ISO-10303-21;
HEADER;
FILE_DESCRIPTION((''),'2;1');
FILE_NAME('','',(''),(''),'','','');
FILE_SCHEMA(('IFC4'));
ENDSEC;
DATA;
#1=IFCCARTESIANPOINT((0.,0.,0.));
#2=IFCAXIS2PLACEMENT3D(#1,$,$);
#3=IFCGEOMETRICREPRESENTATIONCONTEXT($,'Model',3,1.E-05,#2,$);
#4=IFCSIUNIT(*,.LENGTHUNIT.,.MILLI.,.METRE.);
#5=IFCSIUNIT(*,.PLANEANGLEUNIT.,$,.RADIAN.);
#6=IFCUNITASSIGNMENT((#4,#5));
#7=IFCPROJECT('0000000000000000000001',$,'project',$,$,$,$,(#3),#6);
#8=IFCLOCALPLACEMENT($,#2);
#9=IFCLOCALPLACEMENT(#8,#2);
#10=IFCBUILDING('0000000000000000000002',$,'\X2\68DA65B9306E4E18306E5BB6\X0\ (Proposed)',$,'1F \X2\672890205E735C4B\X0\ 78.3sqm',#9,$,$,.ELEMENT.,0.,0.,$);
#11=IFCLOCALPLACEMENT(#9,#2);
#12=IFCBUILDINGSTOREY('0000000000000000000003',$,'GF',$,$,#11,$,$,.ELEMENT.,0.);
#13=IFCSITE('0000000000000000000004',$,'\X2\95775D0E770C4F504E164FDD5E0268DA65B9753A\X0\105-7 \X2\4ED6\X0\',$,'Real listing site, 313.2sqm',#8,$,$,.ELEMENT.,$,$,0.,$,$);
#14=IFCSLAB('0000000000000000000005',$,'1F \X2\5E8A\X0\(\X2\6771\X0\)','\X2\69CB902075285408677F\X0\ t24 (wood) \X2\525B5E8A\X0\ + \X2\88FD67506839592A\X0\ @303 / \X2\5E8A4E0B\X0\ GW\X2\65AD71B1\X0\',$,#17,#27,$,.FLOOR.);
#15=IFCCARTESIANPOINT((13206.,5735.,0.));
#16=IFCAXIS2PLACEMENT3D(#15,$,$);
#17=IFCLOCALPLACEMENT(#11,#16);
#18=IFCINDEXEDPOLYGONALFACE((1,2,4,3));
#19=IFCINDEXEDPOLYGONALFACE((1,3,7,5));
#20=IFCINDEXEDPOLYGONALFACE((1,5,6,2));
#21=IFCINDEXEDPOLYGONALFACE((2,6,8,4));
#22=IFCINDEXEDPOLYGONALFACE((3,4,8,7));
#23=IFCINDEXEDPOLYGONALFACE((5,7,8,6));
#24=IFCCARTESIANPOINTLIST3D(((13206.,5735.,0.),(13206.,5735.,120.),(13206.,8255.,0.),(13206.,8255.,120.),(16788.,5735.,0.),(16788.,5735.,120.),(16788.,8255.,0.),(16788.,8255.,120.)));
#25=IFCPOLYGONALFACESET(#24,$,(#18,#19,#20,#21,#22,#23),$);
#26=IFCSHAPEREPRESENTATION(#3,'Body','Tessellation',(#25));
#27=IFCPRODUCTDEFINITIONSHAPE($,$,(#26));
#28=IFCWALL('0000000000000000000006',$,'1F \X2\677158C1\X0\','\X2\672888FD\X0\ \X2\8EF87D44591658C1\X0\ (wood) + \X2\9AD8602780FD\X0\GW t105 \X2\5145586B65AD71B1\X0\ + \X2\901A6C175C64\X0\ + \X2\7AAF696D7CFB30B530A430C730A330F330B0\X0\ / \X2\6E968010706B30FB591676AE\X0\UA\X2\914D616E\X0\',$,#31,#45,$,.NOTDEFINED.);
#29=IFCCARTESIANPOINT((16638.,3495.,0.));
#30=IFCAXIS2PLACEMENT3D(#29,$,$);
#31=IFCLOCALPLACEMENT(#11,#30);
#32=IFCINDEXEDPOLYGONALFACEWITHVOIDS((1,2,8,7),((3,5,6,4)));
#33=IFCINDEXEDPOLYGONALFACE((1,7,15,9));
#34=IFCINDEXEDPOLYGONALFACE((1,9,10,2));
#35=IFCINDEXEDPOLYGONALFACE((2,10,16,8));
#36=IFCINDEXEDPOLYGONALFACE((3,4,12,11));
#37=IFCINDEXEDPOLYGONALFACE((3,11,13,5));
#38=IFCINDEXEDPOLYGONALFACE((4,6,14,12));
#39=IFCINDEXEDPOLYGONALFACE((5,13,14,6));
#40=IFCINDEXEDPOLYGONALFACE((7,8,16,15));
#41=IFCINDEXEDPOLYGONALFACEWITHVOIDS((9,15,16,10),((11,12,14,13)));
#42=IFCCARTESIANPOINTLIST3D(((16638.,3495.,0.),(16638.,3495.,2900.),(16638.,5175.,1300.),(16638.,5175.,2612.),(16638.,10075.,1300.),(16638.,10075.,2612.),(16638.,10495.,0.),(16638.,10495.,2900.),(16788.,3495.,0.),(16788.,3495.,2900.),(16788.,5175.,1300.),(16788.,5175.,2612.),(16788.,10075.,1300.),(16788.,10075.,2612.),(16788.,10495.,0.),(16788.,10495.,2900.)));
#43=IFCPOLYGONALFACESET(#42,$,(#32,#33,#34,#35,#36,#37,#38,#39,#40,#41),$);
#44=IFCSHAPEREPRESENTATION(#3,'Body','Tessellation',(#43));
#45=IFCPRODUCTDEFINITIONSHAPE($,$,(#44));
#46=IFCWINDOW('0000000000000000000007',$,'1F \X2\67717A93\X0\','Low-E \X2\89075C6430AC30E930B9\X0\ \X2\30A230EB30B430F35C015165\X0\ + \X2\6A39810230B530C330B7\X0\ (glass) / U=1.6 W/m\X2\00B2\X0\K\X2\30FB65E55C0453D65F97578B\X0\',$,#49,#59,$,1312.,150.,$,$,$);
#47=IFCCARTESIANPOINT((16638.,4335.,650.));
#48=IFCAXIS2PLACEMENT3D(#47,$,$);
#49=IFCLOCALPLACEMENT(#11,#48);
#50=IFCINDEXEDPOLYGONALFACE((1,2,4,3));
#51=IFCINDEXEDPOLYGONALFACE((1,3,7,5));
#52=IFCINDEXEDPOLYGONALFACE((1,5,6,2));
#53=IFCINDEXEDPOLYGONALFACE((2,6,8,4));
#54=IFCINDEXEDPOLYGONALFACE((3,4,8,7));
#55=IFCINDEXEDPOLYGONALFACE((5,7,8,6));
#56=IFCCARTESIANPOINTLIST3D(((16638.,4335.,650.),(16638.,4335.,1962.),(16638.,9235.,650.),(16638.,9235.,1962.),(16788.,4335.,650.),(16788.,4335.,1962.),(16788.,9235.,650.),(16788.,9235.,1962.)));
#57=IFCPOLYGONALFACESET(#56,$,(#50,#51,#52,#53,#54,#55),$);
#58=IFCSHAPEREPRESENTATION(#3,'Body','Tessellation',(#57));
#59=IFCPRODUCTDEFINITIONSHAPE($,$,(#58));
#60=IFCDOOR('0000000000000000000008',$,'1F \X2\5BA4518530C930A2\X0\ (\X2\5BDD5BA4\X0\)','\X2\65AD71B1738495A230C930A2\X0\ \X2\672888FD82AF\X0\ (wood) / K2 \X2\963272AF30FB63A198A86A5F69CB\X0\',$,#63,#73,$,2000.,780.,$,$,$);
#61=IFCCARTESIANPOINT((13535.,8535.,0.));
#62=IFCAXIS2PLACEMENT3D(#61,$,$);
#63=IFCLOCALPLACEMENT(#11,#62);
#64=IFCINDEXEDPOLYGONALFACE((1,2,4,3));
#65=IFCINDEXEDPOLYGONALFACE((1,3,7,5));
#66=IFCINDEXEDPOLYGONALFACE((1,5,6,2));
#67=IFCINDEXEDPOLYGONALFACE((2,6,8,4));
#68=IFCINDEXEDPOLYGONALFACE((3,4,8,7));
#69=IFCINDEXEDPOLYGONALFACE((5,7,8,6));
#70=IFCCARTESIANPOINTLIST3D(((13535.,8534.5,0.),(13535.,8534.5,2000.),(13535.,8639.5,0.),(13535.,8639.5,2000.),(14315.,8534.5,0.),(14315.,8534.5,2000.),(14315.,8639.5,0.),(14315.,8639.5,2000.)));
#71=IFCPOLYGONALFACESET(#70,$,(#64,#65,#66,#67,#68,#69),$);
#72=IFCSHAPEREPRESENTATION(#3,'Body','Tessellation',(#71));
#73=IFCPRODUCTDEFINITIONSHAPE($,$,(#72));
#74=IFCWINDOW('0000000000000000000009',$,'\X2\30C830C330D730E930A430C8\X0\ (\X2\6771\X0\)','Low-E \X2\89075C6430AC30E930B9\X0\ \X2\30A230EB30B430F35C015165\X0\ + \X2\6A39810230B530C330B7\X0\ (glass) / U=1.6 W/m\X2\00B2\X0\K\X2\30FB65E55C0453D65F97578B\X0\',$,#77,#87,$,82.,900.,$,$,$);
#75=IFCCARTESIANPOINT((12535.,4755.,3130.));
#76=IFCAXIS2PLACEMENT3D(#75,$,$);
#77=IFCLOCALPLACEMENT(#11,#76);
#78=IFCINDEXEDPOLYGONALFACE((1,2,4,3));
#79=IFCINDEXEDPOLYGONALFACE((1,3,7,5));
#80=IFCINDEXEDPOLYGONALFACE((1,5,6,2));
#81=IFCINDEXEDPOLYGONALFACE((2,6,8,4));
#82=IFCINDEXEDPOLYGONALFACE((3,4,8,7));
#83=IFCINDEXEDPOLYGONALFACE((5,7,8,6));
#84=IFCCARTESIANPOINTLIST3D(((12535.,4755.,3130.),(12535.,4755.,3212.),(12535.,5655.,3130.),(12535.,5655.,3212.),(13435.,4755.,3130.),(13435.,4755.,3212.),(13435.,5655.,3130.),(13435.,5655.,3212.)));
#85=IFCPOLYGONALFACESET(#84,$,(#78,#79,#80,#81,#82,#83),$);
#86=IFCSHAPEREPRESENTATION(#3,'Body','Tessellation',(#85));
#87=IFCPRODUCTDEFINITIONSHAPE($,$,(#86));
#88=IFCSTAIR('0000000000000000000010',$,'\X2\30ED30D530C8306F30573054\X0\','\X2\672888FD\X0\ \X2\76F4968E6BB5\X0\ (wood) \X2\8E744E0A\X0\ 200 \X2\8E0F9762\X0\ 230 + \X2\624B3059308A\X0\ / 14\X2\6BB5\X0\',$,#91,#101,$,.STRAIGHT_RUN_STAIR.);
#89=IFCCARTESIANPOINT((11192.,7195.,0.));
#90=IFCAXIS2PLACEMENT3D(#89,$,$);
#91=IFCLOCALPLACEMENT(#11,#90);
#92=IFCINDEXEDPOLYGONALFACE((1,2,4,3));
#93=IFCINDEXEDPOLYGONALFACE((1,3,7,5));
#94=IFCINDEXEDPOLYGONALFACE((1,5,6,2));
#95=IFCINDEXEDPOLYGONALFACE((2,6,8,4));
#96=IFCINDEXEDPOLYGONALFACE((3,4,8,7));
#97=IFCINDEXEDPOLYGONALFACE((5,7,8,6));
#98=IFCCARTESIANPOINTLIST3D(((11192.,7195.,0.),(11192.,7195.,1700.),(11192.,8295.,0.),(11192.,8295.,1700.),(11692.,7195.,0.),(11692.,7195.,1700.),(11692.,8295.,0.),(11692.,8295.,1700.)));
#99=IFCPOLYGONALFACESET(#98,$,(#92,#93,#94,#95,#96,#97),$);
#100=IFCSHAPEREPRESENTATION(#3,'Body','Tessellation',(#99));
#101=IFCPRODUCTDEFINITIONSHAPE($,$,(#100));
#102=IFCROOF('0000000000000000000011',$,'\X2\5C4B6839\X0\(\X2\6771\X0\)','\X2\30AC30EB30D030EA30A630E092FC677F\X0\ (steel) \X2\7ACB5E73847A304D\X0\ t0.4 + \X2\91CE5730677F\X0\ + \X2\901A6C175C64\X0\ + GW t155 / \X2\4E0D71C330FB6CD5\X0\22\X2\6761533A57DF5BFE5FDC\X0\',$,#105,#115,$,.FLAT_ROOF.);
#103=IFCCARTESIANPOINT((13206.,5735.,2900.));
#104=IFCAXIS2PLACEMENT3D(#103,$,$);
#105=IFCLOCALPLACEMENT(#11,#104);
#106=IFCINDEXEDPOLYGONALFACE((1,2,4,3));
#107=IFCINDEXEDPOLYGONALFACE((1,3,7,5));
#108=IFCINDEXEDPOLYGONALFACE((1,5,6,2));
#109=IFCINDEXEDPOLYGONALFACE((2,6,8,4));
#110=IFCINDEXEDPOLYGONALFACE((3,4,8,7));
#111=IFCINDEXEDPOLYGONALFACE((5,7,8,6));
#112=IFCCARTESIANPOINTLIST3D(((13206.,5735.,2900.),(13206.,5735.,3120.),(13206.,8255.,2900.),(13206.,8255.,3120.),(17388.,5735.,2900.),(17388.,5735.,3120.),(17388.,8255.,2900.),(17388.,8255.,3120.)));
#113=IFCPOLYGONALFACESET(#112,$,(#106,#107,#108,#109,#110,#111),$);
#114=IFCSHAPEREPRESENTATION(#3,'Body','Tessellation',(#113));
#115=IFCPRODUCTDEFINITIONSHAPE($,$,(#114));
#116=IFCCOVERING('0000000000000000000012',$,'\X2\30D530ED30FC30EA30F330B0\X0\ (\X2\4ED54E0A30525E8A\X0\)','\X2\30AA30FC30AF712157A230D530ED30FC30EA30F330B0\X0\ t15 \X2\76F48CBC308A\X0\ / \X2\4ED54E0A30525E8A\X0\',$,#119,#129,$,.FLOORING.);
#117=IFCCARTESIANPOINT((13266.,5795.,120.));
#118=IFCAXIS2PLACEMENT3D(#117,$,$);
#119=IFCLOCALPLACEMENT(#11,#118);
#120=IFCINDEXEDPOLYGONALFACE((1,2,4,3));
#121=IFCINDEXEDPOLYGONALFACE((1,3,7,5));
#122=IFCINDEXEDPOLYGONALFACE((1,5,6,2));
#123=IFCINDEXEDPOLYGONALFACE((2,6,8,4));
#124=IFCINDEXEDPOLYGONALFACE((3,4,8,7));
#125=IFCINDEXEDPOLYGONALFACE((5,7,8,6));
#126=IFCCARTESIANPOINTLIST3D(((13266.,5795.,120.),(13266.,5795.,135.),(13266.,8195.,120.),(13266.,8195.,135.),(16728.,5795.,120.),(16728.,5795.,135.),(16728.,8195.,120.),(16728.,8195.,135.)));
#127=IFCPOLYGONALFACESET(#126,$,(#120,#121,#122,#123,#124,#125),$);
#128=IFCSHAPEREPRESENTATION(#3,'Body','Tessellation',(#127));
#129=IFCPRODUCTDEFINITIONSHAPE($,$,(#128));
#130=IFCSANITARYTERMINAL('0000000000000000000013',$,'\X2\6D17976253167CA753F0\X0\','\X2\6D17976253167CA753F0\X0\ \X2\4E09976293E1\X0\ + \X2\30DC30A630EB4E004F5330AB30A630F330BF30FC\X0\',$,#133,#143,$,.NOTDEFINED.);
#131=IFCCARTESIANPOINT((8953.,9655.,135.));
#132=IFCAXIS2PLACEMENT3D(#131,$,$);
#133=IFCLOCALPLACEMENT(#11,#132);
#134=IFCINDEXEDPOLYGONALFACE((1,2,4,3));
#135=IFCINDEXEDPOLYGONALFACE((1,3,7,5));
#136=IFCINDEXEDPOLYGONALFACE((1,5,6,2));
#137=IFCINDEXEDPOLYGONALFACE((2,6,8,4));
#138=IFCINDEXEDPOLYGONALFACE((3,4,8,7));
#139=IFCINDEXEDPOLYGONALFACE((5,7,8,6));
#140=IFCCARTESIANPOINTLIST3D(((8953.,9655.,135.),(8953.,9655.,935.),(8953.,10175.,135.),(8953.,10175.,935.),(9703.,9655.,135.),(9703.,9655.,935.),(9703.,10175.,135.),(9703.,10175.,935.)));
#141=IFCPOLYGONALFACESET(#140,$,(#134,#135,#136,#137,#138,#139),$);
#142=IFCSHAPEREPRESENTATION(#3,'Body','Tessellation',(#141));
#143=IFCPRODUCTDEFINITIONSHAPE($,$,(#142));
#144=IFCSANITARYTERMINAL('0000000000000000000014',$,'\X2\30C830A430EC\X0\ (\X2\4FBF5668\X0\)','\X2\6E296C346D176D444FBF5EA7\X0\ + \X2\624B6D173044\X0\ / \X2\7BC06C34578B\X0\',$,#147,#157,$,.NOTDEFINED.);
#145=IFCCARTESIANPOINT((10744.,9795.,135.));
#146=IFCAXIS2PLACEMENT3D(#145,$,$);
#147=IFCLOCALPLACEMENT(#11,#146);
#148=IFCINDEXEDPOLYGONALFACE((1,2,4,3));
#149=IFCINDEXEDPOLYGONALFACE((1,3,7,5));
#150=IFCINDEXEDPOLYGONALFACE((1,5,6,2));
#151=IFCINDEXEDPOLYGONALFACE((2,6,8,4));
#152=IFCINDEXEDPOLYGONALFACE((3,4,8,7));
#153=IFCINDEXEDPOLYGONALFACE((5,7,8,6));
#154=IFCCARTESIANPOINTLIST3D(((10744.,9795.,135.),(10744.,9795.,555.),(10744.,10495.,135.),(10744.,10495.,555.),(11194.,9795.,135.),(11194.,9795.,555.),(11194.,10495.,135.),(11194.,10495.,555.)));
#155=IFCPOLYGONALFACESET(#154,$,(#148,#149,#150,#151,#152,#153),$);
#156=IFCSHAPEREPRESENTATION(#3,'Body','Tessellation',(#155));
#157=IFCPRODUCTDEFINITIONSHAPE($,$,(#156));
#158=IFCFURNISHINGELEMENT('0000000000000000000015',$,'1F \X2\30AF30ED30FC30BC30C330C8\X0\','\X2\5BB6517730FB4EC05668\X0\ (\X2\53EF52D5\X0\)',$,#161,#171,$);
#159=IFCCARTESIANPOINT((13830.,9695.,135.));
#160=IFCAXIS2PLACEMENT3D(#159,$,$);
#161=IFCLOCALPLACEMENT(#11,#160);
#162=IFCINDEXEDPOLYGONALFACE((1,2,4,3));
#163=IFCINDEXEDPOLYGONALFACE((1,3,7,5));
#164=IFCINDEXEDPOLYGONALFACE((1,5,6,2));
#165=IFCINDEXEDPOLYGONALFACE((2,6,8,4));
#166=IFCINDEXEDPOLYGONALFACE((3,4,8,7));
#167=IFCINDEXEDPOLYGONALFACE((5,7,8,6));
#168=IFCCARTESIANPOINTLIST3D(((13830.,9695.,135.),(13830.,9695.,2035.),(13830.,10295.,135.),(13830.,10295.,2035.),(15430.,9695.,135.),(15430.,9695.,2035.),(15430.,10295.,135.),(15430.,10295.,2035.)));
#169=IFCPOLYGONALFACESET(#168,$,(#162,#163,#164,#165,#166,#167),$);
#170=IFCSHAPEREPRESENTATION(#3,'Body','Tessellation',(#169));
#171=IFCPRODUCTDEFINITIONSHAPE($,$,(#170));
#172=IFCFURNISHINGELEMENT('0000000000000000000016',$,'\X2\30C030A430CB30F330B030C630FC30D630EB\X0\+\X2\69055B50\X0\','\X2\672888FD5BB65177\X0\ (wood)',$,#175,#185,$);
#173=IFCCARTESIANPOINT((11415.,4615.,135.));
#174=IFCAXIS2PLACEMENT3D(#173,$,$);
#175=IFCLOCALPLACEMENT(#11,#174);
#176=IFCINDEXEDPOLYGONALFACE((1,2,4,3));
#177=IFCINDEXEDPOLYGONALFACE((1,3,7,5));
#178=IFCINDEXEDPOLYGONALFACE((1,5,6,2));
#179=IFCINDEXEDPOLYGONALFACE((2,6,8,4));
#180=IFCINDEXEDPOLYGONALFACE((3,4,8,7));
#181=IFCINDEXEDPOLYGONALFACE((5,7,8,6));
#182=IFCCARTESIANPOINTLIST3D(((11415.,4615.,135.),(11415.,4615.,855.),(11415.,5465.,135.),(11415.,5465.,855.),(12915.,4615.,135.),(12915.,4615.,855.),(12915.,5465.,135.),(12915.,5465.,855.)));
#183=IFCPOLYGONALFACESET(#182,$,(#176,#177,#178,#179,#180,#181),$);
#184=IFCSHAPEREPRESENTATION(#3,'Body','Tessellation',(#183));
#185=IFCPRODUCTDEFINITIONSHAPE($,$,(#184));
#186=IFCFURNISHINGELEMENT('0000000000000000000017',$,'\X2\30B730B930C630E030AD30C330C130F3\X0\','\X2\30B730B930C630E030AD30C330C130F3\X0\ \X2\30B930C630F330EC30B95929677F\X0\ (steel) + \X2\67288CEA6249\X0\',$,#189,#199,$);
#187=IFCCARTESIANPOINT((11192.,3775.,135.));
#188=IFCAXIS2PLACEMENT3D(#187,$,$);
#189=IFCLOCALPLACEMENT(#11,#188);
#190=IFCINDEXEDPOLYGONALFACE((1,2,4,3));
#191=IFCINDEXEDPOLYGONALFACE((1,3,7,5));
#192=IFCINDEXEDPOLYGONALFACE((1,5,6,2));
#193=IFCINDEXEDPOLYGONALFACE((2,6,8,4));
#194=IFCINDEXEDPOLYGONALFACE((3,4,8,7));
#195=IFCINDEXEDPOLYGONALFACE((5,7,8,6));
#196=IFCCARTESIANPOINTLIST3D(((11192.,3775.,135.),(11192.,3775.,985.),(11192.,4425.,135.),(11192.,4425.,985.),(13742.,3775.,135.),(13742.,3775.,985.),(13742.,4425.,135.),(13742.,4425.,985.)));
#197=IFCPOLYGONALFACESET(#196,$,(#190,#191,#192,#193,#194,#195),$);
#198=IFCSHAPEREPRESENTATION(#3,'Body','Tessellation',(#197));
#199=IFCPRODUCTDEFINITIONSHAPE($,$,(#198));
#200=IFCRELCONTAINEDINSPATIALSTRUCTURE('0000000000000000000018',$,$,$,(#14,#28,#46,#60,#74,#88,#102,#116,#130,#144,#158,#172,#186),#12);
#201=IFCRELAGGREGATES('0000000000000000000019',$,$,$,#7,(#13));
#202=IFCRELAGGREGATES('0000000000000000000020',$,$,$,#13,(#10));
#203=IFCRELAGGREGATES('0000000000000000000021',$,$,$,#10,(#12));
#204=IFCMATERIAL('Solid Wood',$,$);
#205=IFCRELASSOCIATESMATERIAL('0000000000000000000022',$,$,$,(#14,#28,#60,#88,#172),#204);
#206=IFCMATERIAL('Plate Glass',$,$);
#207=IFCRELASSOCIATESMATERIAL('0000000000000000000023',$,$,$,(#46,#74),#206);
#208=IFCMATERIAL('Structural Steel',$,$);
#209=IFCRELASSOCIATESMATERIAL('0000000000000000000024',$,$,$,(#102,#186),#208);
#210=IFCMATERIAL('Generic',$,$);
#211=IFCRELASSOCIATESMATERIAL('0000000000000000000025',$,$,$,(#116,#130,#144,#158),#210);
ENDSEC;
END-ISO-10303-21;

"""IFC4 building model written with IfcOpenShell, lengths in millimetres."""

from ifc_helpers import new_model, si_unit, frame, frame_2d, origin, place, context, project, spatial, rectangle, extrude, material, element, fill, save


model = new_model("IFC4")

# Units and contexts
model_context = context("Model", 3, precision=1e-05, world=origin())
ifc_project = project(units=[si_unit("LENGTHUNIT", "METRE", prefix="MILLI"), si_unit("PLANEANGLEUNIT", "RADIAN")], contexts=[model_context])

# Site, building, storey
site_placement = place(None, origin())
site = spatial("IfcSite", under=ifc_project, at=site_placement, Name="長崎県佐世保市棚方町105-7 他", ObjectType="Real listing site, 313.2sqm", CompositionType="ELEMENT", RefElevation=0.0)
building_placement = place(site_placement, origin())
building = spatial("IfcBuilding", under=site, at=building_placement, Name="棚方の丘の家 (Proposed)", ObjectType="1F 木造平屋 78.3sqm", CompositionType="ELEMENT", ElevationOfRefHeight=0.0, ElevationOfTerrain=0.0)
storey_placement = place(building_placement, origin())
storey = spatial("IfcBuildingStorey", under=building, at=storey_placement, Name="GF", CompositionType="ELEMENT", Elevation=0.0)

# Slab
ifc_material_1 = material(Name="Solid Wood")
slab_1_placement = place(storey_placement, frame((13206.0, 5735.0, 0.0)))
element("IfcSlab", 1, at=slab_1_placement, inside=storey, material=ifc_material_1, Name="1F 床(東)", Description="構造用合板 t24 (wood) 剛床 + 製材根太 @303 / 床下 GW断熱", PredefinedType="FLOOR", context=model_context, shape_type="SweptSolid", body=[
    extrude(rectangle(XDim=3582.0, YDim=2520.0, at=frame_2d((1791.0, 1260.0))), frame((13206.0, 5735.0, 0.0)), (0.0, 0.0, 1.0), 120.0),
])

# Wall, opening, window
wall_1_placement = place(storey_placement, frame((16638.0, 3495.0, 0.0)))
wall_1 = element("IfcWall", 2, at=wall_1_placement, inside=storey, material=ifc_material_1, Name="1F 東壁", Description="木製 軸組外壁 (wood) + 高性能GW t105 充填断熱 + 通気層 + 窯業系サイディング / 準耐火・外皮UA配慮", PredefinedType="NOTDEFINED", context=model_context, shape_type="SweptSolid", body=[
    extrude(rectangle(XDim=150.0, YDim=7000.0, at=frame_2d((75.0, 3500.0))), frame((16638.0, 3495.0, 0.0)), (0.0, 0.0, 1.0), 2900.0),
])
opening_1_placement = place(storey_placement, frame((16638.0, 4335.0, 650.0)))
opening_1 = element("IfcOpeningElement", 3, at=opening_1_placement, cuts=wall_1, PredefinedType="NOTDEFINED", context=model_context, shape_type="SweptSolid", body=[
    extrude(rectangle(XDim=150.0, YDim=4900.0, at=frame_2d((75.0, 2450.0))), frame((16638.0, 4335.0, 650.0)), (0.0, 0.0, 1.0), 1312.0),
])
ifc_material_2 = material(Name="Plate Glass")
window_1_placement = place(storey_placement, frame((16638.0, 4335.0, 650.0)))
window_1 = element("IfcWindow", 4, at=window_1_placement, inside=storey, material=ifc_material_2, Name="1F 東窓", Description="Low-E 複層ガラス アルゴン封入 + 樹脂サッシ (glass) / U=1.6 W/m²K・日射取得型", OverallHeight=1312.0, OverallWidth=150.0, context=model_context, shape_type="SweptSolid", body=[
    extrude(rectangle(XDim=150.0, YDim=4900.0, at=frame_2d((75.0, 2450.0))), frame((16638.0, 4335.0, 650.0)), (0.0, 0.0, 1.0), 1312.0),
])
fill(opening_1, window_1)

# Door
door_placement = place(storey_placement, frame((13535.0, 8535.0, 0.0)))
element("IfcDoor", 5, at=door_placement, inside=storey, material=ifc_material_1, Name="1F 室内ドア (寝室)", Description="断熱玄関ドア 木製芯 (wood) / K2 防犯・採風機構", OverallHeight=2000.0, OverallWidth=780.0, context=model_context, shape_type="SweptSolid", body=[
    extrude(rectangle(XDim=780.0, YDim=105.0, at=frame_2d((390.0, 52.0))), frame((13535.0, 8535.0, 0.0)), (0.0, 0.0, 1.0), 2000.0),
])

# Window
window_2_placement = place(storey_placement, frame((12535.0, 4755.0, 3130.0)))
element("IfcWindow", 6, at=window_2_placement, inside=storey, material=ifc_material_2, Name="トップライト (東)", Description="Low-E 複層ガラス アルゴン封入 + 樹脂サッシ (glass) / U=1.6 W/m²K・日射取得型", OverallHeight=82.0, OverallWidth=900.0, context=model_context, shape_type="SweptSolid", body=[
    extrude(rectangle(XDim=900.0, YDim=900.0, at=frame_2d((450.0, 450.0))), frame((12535.0, 4755.0, 3130.0)), (0.0, 0.0, 1.0), 82.0),
])

# Stair
stair_placement = place(storey_placement, frame((11192.0, 7195.0, 0.0)))
element("IfcStair", 7, at=stair_placement, inside=storey, material=ifc_material_1, Name="ロフトはしご", Description="木製 直階段 (wood) 蹴上 200 踏面 230 + 手すり / 14段", PredefinedType="STRAIGHT_RUN_STAIR", context=model_context, shape_type="SweptSolid", body=[
    extrude(rectangle(XDim=500.0, YDim=1100.0, at=frame_2d((250.0, 550.0))), frame((11192.0, 7195.0, 0.0)), (0.0, 0.0, 1.0), 1700.0),
])

# Roof
ifc_material_3 = material(Name="Structural Steel")
roof_placement = place(storey_placement, frame((13206.0, 5735.0, 2900.0)))
element("IfcRoof", 8, at=roof_placement, inside=storey, material=ifc_material_3, Name="屋根(東)", Description="ガルバリウム鋼板 (steel) 立平葺き t0.4 + 野地板 + 通気層 + GW t155 / 不燃・法22条区域対応", PredefinedType="FLAT_ROOF", context=model_context, shape_type="SweptSolid", body=[
    extrude(rectangle(XDim=4182.0, YDim=2520.0, at=frame_2d((2091.0, 1260.0))), frame((13206.0, 5735.0, 2900.0)), (0.0, 0.0, 1.0), 220.0),
])

# Covering
ifc_material_4 = material(Name="Generic")
covering_placement = place(storey_placement, frame((13266.0, 5795.0, 120.0)))
element("IfcCovering", 9, at=covering_placement, inside=storey, material=ifc_material_4, Name="フローリング (仕上げ床)", Description="オーク無垢フローリング t15 直貼り / 仕上げ床", PredefinedType="FLOORING", context=model_context, shape_type="SweptSolid", body=[
    extrude(rectangle(XDim=3462.0, YDim=2400.0, at=frame_2d((1731.0, 1200.0))), frame((13266.0, 5795.0, 120.0)), (0.0, 0.0, 1.0), 15.0),
])

# Sanitary terminals
sanitary_terminal_1_placement = place(storey_placement, frame((8953.0, 9655.0, 135.0)))
element("IfcSanitaryTerminal", 10, at=sanitary_terminal_1_placement, inside=storey, material=ifc_material_4, Name="洗面化粧台", Description="洗面化粧台 三面鏡 + ボウル一体カウンター", PredefinedType="NOTDEFINED", context=model_context, shape_type="SweptSolid", body=[
    extrude(rectangle(XDim=750.0, YDim=520.0, at=frame_2d((375.0, 260.0))), frame((8953.0, 9655.0, 135.0)), (0.0, 0.0, 1.0), 800.0),
])
sanitary_terminal_2_placement = place(storey_placement, frame((10744.0, 9795.0, 135.0)))
element("IfcSanitaryTerminal", 11, at=sanitary_terminal_2_placement, inside=storey, material=ifc_material_4, Name="トイレ (便器)", Description="温水洗浄便座 + 手洗い / 節水型", PredefinedType="NOTDEFINED", context=model_context, shape_type="SweptSolid", body=[
    extrude(rectangle(XDim=450.0, YDim=700.0, at=frame_2d((225.0, 350.0))), frame((10744.0, 9795.0, 135.0)), (0.0, 0.0, 1.0), 420.0),
])

# Furnishing elements
furnishing_1_placement = place(storey_placement, frame((13830.0, 9695.0, 135.0)))
element("IfcFurnishingElement", 12, at=furnishing_1_placement, inside=storey, material=ifc_material_4, Name="1F クローゼット", Description="家具・什器 (可動)", context=model_context, shape_type="SweptSolid", body=[
    extrude(rectangle(XDim=1600.0, YDim=600.0, at=frame_2d((800.0, 300.0))), frame((13830.0, 9695.0, 135.0)), (0.0, 0.0, 1.0), 1900.0),
])
furnishing_2_placement = place(storey_placement, frame((11415.0, 4615.0, 135.0)))
element("IfcFurnishingElement", 13, at=furnishing_2_placement, inside=storey, material=ifc_material_1, Name="ダイニングテーブル+椅子", Description="木製家具 (wood)", context=model_context, shape_type="SweptSolid", body=[
    extrude(rectangle(XDim=1500.0, YDim=850.0, at=frame_2d((750.0, 425.0))), frame((11415.0, 4615.0, 135.0)), (0.0, 0.0, 1.0), 720.0),
])
furnishing_3_placement = place(storey_placement, frame((11192.0, 3775.0, 135.0)))
element("IfcFurnishingElement", 14, at=furnishing_3_placement, inside=storey, material=ifc_material_3, Name="システムキッチン", Description="システムキッチン ステンレス天板 (steel) + 木質扉", context=model_context, shape_type="SweptSolid", body=[
    extrude(rectangle(XDim=2550.0, YDim=650.0, at=frame_2d((1275.0, 325.0))), frame((11192.0, 3775.0, 135.0)), (0.0, 0.0, 1.0), 850.0),
])

save(model, "model.ifc")
